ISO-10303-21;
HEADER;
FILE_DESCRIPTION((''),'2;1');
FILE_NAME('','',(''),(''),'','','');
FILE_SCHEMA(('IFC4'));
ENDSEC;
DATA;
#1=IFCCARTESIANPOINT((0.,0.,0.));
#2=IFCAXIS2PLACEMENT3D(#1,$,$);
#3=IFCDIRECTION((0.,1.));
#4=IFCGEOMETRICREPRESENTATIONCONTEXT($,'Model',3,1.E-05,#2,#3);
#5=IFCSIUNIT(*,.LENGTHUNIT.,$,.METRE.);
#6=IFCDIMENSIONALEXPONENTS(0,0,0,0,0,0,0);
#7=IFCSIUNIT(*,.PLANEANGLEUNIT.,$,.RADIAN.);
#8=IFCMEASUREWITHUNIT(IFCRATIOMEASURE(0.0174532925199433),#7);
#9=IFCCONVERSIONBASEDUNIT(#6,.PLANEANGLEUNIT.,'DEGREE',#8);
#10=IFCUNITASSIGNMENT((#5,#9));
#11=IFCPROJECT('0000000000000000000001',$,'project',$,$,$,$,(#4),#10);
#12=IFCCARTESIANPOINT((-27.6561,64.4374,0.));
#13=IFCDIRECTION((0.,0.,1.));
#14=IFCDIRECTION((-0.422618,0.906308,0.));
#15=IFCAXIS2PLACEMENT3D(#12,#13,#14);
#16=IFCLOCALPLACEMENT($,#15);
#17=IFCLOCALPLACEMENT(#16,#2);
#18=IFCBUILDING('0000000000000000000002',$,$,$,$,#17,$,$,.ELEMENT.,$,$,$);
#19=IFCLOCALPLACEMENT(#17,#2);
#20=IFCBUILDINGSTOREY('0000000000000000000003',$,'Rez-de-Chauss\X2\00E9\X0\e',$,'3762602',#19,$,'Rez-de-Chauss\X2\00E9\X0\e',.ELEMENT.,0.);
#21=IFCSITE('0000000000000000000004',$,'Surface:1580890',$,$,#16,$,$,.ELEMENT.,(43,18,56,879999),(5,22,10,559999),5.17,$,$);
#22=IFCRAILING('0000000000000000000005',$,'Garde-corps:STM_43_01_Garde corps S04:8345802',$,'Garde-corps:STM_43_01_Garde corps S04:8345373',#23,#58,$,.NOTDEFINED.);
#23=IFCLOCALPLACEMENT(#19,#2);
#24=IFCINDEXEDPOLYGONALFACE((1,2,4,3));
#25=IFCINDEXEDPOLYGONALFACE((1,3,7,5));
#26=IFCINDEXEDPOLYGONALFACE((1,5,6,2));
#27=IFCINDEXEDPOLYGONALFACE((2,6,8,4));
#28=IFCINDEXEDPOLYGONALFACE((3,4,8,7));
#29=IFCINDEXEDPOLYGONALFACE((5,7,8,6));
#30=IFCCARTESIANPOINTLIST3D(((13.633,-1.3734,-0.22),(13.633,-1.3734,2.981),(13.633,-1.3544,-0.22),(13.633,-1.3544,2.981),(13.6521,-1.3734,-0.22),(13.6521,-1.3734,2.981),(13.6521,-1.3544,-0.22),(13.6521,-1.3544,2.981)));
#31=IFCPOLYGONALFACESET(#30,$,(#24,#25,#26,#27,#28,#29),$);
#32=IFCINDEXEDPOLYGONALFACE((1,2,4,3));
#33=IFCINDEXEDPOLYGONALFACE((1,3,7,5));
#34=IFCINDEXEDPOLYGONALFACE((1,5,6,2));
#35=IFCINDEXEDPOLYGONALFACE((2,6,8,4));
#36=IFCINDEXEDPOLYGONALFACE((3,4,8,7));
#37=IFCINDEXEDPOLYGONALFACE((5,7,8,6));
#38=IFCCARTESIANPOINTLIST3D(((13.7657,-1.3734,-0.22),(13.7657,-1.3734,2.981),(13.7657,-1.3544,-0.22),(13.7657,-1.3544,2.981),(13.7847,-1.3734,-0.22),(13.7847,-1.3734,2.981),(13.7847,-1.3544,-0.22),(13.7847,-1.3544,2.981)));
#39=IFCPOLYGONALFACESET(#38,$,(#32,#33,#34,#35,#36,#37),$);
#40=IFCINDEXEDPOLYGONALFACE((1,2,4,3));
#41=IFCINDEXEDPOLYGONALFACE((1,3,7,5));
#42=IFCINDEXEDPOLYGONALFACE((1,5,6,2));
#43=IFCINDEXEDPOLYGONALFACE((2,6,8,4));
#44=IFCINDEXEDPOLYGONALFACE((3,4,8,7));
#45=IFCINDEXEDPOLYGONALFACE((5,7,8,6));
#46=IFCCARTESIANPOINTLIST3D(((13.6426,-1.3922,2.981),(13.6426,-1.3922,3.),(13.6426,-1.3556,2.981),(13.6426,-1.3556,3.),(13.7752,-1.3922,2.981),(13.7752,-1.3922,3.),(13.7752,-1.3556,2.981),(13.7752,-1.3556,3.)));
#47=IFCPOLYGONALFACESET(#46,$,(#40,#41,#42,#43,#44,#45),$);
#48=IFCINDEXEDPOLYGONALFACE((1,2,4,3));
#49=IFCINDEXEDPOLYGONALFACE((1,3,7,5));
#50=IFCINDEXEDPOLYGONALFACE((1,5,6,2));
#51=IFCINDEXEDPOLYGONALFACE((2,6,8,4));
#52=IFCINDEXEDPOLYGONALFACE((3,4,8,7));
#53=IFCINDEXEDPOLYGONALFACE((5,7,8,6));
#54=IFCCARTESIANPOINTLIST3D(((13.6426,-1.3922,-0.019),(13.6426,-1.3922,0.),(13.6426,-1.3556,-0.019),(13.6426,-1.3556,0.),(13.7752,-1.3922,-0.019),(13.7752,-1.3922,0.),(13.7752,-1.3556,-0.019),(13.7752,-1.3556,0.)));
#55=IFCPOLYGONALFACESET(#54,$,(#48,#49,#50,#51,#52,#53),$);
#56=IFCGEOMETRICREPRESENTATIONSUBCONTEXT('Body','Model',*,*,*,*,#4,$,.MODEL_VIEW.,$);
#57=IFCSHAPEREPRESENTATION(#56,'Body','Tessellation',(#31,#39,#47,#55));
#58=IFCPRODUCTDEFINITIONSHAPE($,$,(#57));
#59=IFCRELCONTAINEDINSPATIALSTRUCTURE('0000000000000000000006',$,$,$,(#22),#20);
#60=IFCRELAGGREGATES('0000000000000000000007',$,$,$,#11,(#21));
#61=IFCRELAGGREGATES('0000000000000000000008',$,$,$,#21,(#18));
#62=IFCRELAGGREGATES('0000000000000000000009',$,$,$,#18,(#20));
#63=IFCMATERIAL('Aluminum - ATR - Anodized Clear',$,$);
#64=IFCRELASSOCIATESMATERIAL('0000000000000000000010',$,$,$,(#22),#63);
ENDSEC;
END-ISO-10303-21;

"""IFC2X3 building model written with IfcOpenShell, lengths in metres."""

from ifc_helpers import new_model, entity, si_unit, converted_unit, direction, frame, frame_2d, origin, origin_2d_with_axis, place, context, subcontext, project, spatial, rectangle, extrude, material, element, save


model = new_model("IFC2X3")

# Units and contexts
model_context = context("Model", 3, precision=1e-05, world=origin(), true_north=direction((0.0, 1.0)))
body_context = subcontext(model_context, "Body", "Model", "MODEL_VIEW")
ifc_project = project(units=[si_unit("LENGTHUNIT", "METRE"), converted_unit("PLANEANGLEUNIT", "DEGREE", entity("IfcRatioMeasure", 0.0174532925199433), si_unit("PLANEANGLEUNIT", "RADIAN"), dimensions=[0, 0, 0, 0, 0, 0, 0])], contexts=[model_context])

# Site, building, storey
site_placement = place(None, frame((-27.6561, 64.4374, 0.0), z_axis=(0.0, 0.0, 1.0), x_axis=(-0.422618, 0.906308, 0.0)))
site = spatial("IfcSite", under=ifc_project, at=site_placement, Name="Surface:1580890", CompositionType="ELEMENT", RefLatitude=(43, 18, 56, 879999), RefLongitude=(5, 22, 10, 559999), RefElevation=5.17)
building_placement = place(site_placement, origin())
building = spatial("IfcBuilding", under=site, at=building_placement, CompositionType="ELEMENT")
storey_placement = place(building_placement, origin())
storey = spatial("IfcBuildingStorey", under=building, at=storey_placement, Name="Rez-de-Chaussée", ObjectType="3762602", LongName="Rez-de-Chaussée", CompositionType="ELEMENT", Elevation=0.0)

# Railing
ifc_material_1 = material(Name="Aluminum - ATR - Anodized Clear")
railing_1_placement = place(storey_placement, origin())
element("IfcRailing", 1, at=railing_1_placement, inside=storey, material=ifc_material_1, Name="Garde-corps:STM_43_01_Garde corps S04:8345802", ObjectType="Garde-corps:STM_43_01_Garde corps S04:8345373", PredefinedType="NOTDEFINED", context=body_context, shape_type="SweptSolid", body=[
    extrude(rectangle(XDim=0.0191, YDim=0.019, at=origin_2d_with_axis()), frame((13.6426, -1.3639, -0.22), z_axis=(0.0, 0.0, 1.0), x_axis=(-1.0, 0.0, 0.0)), (0.0, 0.0, 1.0), 3.201),
    extrude(rectangle(XDim=0.0191, YDim=0.019, at=origin_2d_with_axis()), frame((13.7752, -1.3639, -0.22), z_axis=(0.0, 0.0, 1.0), x_axis=(-1.0, 0.0, 0.0)), (0.0, 0.0, 1.0), 3.201),
    extrude(rectangle(XDim=0.1327, YDim=0.0366, at=frame_2d((0.0, 0.0), x_axis=(1.0, 0.0))), frame((13.7089, -1.3739, 2.9809), z_axis=(0.0, 0.0, 1.0), x_axis=(-1.0, 0.0, 0.0)), (0.0, 0.0, 1.0), 0.0191),
    extrude(rectangle(XDim=0.1327, YDim=0.0366, at=frame_2d((0.0, 0.0), x_axis=(1.0, 0.0))), frame((13.7089, -1.3739, -0.019), z_axis=(0.0, 0.0, 1.0), x_axis=(-1.0, 0.0, 0.0)), (0.0, 0.0, 1.0), 0.0191),
])

save(model, "model.ifc")
